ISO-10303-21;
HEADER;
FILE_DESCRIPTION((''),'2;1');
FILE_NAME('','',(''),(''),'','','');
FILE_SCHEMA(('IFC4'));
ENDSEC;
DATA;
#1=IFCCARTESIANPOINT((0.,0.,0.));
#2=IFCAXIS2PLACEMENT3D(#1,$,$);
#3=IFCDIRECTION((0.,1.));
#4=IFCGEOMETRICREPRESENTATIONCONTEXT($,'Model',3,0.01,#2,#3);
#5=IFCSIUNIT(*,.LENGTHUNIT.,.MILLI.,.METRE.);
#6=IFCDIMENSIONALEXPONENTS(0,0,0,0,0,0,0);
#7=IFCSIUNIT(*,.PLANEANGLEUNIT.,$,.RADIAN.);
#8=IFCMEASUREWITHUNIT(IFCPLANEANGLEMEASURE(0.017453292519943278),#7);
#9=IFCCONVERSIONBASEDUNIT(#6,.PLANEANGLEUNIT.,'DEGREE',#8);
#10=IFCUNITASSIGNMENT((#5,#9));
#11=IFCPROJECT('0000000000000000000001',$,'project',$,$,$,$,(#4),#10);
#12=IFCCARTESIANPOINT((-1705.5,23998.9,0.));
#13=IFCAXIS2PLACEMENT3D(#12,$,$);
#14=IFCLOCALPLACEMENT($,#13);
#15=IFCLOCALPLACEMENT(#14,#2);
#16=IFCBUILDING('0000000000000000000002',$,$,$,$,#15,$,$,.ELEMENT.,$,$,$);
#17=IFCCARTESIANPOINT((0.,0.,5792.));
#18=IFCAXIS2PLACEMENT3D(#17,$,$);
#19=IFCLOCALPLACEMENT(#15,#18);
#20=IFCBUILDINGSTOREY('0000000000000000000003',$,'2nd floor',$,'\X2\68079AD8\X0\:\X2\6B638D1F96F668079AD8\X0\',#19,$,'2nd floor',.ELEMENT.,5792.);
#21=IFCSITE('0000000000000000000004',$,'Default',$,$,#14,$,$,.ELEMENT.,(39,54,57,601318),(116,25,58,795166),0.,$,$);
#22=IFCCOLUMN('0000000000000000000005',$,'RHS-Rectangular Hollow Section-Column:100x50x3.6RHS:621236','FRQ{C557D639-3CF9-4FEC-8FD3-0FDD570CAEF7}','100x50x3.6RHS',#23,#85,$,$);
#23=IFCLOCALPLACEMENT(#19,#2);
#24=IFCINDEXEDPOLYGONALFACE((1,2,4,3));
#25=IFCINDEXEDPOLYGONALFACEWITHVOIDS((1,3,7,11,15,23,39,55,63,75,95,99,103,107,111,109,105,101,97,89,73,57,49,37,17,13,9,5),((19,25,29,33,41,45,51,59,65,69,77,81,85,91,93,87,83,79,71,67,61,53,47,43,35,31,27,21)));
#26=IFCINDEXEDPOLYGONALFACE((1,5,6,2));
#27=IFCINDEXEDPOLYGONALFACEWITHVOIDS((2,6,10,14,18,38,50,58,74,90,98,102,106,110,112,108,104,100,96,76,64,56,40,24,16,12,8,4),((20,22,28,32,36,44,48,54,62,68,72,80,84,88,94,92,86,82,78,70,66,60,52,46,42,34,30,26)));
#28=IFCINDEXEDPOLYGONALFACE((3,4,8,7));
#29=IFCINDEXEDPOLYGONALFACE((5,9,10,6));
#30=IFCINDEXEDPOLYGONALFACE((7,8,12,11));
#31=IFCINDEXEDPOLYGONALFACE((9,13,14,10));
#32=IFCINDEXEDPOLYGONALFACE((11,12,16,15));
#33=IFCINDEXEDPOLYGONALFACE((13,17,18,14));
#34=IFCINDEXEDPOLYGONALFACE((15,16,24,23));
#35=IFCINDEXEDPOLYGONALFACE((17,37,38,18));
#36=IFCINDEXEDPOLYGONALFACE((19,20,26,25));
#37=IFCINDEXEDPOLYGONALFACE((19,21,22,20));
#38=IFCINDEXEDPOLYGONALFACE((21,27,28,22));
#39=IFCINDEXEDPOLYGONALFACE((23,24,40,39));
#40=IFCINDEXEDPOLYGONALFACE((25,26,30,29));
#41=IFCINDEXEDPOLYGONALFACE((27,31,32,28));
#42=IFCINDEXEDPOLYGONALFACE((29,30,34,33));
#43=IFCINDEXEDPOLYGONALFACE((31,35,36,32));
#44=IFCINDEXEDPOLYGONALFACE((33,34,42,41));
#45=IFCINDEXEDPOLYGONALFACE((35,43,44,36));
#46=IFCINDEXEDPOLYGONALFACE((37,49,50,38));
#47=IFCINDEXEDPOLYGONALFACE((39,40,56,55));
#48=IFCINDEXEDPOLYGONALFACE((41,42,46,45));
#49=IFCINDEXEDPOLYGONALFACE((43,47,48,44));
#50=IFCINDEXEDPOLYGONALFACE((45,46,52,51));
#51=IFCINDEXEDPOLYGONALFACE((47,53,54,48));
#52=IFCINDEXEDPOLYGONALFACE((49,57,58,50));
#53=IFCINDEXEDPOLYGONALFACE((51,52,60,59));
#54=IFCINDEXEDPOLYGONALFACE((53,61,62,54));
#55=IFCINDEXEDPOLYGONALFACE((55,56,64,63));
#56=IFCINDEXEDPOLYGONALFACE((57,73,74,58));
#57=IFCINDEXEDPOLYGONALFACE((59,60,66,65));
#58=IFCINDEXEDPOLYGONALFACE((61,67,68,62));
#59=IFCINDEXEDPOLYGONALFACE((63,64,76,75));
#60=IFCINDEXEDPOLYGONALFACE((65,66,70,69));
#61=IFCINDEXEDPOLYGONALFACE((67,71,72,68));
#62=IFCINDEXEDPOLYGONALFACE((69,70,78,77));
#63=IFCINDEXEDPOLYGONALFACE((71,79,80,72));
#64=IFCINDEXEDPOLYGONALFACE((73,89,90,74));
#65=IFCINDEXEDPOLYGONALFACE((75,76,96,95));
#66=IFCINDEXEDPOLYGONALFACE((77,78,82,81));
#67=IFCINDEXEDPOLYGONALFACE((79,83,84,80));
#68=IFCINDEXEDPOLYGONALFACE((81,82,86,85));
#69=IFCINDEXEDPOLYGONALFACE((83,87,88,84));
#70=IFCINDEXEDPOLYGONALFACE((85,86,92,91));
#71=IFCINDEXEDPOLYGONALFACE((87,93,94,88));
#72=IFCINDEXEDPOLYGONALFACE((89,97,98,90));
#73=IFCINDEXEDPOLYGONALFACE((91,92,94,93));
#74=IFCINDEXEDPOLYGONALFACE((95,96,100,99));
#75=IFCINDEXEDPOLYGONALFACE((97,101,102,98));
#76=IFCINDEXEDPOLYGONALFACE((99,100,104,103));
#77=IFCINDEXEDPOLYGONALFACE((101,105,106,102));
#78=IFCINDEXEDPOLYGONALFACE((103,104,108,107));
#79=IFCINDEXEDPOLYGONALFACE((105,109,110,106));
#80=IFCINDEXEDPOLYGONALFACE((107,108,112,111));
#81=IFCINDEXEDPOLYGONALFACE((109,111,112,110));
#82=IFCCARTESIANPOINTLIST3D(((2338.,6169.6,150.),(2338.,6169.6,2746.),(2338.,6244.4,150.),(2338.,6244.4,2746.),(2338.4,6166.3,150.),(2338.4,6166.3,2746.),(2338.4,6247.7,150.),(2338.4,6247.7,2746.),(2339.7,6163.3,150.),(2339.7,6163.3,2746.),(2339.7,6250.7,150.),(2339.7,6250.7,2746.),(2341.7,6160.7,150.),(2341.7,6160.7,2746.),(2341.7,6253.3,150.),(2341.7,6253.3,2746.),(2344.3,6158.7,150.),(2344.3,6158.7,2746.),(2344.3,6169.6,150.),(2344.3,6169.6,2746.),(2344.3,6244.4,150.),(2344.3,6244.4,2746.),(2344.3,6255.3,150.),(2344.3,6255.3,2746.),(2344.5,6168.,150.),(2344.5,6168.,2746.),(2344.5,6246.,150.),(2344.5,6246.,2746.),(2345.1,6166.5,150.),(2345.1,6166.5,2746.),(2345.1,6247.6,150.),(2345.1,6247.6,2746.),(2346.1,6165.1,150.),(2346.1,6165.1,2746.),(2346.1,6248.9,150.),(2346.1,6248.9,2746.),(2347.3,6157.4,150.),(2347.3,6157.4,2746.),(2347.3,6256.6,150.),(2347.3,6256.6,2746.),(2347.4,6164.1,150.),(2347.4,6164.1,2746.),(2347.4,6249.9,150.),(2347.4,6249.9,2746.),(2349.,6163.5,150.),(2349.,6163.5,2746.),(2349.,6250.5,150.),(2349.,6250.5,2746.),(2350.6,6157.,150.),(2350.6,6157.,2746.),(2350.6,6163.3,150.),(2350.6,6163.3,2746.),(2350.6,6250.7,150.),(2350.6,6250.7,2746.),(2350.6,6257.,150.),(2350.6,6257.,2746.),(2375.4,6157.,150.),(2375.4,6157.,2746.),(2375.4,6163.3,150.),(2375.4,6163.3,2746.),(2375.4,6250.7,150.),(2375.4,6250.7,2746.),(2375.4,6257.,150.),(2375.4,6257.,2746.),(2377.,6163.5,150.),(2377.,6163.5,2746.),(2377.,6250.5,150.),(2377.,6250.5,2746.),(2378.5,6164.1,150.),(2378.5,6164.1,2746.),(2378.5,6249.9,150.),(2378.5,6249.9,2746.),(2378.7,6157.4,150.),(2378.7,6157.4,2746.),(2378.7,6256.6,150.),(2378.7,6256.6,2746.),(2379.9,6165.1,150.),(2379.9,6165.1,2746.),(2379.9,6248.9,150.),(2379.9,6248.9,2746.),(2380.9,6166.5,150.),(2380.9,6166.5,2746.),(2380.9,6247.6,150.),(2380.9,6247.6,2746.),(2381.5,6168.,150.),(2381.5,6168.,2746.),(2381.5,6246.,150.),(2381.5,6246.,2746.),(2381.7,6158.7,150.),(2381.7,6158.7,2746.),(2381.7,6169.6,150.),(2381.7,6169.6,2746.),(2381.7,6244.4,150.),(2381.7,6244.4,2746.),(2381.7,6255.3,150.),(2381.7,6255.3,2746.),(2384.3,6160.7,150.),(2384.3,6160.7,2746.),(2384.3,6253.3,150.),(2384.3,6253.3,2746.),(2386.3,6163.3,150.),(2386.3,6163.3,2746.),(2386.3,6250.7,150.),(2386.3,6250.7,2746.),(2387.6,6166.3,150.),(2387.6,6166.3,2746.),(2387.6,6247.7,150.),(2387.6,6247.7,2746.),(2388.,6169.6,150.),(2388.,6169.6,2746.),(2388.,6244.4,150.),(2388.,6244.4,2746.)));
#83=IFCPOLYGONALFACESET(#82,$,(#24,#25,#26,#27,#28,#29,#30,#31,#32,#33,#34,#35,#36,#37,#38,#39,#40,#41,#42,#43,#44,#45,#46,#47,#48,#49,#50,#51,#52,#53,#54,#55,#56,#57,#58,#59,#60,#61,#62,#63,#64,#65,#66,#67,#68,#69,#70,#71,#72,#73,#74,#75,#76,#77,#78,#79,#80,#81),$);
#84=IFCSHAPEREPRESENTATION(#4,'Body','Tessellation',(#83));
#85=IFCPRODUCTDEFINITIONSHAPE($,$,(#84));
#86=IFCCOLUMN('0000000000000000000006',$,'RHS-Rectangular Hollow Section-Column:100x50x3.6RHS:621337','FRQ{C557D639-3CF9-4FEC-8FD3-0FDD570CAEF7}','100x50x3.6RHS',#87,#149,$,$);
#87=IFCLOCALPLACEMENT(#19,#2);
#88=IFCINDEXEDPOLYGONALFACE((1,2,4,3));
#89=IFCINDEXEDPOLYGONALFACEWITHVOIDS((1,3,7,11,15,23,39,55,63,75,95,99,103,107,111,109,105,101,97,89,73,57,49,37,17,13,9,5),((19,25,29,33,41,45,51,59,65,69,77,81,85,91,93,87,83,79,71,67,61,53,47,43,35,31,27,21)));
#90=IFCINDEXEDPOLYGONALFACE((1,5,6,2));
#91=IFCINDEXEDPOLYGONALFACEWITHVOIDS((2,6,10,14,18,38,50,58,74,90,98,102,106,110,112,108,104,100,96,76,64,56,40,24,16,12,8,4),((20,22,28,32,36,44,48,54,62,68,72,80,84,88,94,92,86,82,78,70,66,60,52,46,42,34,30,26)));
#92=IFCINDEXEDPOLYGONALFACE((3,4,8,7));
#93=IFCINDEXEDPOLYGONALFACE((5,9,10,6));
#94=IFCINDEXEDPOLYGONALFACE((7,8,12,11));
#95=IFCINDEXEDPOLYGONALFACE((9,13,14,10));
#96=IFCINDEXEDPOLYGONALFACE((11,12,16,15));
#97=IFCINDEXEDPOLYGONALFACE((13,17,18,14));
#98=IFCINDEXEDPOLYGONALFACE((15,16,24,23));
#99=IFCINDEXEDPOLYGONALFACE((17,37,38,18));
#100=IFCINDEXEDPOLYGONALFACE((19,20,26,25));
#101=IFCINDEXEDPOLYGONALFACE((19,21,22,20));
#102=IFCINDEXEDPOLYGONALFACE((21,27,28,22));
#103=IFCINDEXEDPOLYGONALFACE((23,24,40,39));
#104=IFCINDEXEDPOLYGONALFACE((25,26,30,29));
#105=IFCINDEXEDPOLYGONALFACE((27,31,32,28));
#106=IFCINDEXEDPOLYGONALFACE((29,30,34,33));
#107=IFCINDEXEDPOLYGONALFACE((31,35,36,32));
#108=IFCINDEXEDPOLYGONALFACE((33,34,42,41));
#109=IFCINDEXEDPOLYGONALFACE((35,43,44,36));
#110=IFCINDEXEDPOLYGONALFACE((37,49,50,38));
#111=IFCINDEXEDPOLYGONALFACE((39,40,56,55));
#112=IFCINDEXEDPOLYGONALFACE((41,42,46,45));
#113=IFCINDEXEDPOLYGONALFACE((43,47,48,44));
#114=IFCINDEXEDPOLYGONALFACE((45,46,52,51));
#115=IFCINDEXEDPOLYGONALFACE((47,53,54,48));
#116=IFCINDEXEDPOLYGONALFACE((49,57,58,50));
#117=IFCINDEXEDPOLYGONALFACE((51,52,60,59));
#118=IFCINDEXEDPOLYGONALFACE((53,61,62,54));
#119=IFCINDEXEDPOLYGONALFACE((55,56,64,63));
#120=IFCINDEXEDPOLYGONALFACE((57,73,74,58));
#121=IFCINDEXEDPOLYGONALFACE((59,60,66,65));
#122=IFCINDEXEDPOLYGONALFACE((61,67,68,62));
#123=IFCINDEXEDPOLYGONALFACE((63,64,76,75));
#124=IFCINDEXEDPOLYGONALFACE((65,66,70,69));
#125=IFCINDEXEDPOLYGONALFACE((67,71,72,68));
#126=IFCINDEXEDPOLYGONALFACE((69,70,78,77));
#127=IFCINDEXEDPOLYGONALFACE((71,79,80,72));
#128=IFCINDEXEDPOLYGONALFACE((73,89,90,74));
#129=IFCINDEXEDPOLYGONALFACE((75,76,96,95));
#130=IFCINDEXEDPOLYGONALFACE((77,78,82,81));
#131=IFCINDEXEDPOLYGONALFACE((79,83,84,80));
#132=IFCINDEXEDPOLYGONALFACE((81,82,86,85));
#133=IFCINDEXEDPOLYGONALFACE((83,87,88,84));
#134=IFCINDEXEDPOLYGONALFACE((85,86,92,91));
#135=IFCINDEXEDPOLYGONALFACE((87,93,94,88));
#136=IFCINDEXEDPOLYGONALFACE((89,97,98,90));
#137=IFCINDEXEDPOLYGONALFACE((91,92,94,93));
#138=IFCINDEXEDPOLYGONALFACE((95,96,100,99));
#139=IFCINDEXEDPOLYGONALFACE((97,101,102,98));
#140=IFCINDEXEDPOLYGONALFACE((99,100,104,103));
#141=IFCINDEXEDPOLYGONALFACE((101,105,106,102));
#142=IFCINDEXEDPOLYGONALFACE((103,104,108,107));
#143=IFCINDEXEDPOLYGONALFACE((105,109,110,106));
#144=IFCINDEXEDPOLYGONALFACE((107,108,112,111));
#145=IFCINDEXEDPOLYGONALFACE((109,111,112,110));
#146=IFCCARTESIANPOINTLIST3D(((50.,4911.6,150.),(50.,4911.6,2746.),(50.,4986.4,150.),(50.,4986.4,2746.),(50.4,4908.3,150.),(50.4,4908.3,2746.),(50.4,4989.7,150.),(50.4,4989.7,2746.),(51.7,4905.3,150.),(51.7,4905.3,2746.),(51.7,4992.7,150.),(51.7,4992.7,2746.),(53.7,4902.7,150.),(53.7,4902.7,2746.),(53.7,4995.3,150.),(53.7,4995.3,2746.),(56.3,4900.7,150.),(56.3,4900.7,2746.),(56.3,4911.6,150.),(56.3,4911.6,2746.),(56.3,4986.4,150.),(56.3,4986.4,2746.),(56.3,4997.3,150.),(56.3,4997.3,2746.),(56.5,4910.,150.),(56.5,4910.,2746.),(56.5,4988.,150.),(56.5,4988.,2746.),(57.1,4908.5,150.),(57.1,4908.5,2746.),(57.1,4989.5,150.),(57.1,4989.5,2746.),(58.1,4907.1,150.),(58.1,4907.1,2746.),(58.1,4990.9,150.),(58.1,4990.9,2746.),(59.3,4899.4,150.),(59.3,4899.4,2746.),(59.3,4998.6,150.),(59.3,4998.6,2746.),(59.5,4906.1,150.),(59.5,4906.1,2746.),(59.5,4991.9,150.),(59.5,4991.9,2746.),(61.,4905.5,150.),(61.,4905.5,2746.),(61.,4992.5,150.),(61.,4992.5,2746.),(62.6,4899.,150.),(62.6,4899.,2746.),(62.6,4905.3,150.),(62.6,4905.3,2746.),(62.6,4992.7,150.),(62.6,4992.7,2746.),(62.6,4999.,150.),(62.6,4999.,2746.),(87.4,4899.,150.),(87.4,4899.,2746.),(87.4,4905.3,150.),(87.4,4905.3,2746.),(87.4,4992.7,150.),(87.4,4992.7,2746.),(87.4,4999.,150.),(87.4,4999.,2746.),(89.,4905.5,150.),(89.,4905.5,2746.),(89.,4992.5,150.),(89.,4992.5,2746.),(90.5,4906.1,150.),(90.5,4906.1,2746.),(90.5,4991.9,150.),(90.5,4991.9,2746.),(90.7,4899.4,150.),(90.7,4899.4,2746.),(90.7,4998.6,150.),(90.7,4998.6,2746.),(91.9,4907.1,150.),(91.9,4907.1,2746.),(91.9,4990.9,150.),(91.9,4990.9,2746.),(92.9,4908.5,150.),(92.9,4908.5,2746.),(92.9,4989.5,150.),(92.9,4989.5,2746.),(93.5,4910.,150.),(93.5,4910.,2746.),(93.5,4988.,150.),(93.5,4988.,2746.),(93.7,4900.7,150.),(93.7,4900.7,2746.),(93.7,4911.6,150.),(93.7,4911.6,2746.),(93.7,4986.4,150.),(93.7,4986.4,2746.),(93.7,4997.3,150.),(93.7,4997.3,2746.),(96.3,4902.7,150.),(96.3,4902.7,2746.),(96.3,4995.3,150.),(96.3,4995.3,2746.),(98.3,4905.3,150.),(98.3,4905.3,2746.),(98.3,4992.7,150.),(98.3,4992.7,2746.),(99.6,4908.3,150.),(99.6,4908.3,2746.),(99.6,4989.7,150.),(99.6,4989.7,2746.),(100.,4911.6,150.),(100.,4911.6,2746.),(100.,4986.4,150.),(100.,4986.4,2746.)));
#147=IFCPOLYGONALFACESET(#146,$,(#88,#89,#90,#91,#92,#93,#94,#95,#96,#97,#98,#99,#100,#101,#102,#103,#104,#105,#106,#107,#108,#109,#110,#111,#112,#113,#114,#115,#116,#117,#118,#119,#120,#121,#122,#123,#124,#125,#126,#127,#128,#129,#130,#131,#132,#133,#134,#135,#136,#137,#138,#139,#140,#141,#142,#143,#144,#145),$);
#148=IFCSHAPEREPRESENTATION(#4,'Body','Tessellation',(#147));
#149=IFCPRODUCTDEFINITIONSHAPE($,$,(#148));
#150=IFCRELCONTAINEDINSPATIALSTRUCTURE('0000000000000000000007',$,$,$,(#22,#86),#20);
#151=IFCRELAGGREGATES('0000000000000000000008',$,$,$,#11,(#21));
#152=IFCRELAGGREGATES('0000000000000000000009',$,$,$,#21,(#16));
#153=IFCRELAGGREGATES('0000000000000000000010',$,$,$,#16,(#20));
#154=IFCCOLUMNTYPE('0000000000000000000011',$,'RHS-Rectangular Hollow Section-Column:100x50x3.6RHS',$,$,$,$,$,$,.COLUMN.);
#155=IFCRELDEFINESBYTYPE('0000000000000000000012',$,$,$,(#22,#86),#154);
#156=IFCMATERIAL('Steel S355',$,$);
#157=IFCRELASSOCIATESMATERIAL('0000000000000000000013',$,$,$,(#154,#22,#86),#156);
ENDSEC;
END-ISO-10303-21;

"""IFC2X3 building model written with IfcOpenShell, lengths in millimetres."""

from ifc_helpers import new_model, entity, si_unit, converted_unit, direction, frame, origin, origin_2d, place, context, project, spatial, hollow_rectangle, extrude, clip, halfspace, material, type_object, element, save


model = new_model("IFC2X3")

# Units and contexts
model_context = context("Model", 3, precision=0.01, world=origin(), true_north=direction((0.0, 1.0)))
ifc_project = project(units=[si_unit("LENGTHUNIT", "METRE", prefix="MILLI"), converted_unit("PLANEANGLEUNIT", "DEGREE", entity("IfcPlaneAngleMeasure", 0.017453292519943278), si_unit("PLANEANGLEUNIT", "RADIAN"), dimensions=[0, 0, 0, 0, 0, 0, 0])], contexts=[model_context])

# Site, building, storey
site_placement = place(None, frame((-1705.5, 23998.9, 0.0)))
site = spatial("IfcSite", under=ifc_project, at=site_placement, Name="Default", CompositionType="ELEMENT", RefLatitude=(39, 54, 57, 601318), RefLongitude=(116, 25, 58, 795166), RefElevation=0.0)
building_placement = place(site_placement, origin())
building = spatial("IfcBuilding", under=site, at=building_placement, CompositionType="ELEMENT")
storey_placement = place(building_placement, frame((0.0, 0.0, 5792.0)))
storey = spatial("IfcBuildingStorey", under=building, at=storey_placement, Name="2nd floor", ObjectType="标高:正负零标高", LongName="2nd floor", CompositionType="ELEMENT", Elevation=5792.0)

# Columns
ifc_material_1 = material(Name="Steel S355")
column_type_1 = type_object("IfcColumnType", Name="RHS-Rectangular Hollow Section-Column:100x50x3.6RHS", PredefinedType="COLUMN", material=ifc_material_1)
column_1_placement = place(storey_placement, frame((2363.0, 6207.0, 2746.0), z_axis=(0.0, 0.0, 1.0), x_axis=(-1.0, 0.0, 0.0)))
element("IfcColumn", 1, at=column_1_placement, inside=storey, type_object=column_type_1, material=ifc_material_1, Name="RHS-Rectangular Hollow Section-Column:100x50x3.6RHS:621236", Description="FRQ{C557D639-3CF9-4FEC-8FD3-0FDD570CAEF7}", ObjectType="100x50x3.6RHS", context=model_context, shape_type="Clipping", body=[
    clip(extrude(hollow_rectangle(XDim=50.0, YDim=100.0, WallThickness=6.3, InnerFilletRadius=6.3, OuterFilletRadius=12.6, at=origin_2d()), origin(), (0.0, 0.0, -1.0), 2651.9), halfspace(frame((2363.0, 6207.0, -2596.0), z_axis=(0.0, 0.0, 1.0), x_axis=(-1.0, 0.0, 0.0)), True)),
])
column_2_placement = place(storey_placement, frame((75.0, 4949.0, 2746.0), z_axis=(0.0, 0.0, 1.0), x_axis=(-1.0, 0.0, 0.0)))
element("IfcColumn", 2, at=column_2_placement, inside=storey, type_object=column_type_1, material=ifc_material_1, Name="RHS-Rectangular Hollow Section-Column:100x50x3.6RHS:621337", Description="FRQ{C557D639-3CF9-4FEC-8FD3-0FDD570CAEF7}", ObjectType="100x50x3.6RHS", context=model_context, shape_type="Clipping", body=[
    clip(extrude(hollow_rectangle(XDim=50.0, YDim=100.0, WallThickness=6.3, InnerFilletRadius=6.3, OuterFilletRadius=12.6, at=origin_2d()), origin(), (0.0, 0.0, -1.0), 2651.9), halfspace(frame((75.0, 4949.0, -2596.0), z_axis=(0.0, 0.0, 1.0), x_axis=(-1.0, 0.0, 0.0)), True)),
])

save(model, "model.ifc")
